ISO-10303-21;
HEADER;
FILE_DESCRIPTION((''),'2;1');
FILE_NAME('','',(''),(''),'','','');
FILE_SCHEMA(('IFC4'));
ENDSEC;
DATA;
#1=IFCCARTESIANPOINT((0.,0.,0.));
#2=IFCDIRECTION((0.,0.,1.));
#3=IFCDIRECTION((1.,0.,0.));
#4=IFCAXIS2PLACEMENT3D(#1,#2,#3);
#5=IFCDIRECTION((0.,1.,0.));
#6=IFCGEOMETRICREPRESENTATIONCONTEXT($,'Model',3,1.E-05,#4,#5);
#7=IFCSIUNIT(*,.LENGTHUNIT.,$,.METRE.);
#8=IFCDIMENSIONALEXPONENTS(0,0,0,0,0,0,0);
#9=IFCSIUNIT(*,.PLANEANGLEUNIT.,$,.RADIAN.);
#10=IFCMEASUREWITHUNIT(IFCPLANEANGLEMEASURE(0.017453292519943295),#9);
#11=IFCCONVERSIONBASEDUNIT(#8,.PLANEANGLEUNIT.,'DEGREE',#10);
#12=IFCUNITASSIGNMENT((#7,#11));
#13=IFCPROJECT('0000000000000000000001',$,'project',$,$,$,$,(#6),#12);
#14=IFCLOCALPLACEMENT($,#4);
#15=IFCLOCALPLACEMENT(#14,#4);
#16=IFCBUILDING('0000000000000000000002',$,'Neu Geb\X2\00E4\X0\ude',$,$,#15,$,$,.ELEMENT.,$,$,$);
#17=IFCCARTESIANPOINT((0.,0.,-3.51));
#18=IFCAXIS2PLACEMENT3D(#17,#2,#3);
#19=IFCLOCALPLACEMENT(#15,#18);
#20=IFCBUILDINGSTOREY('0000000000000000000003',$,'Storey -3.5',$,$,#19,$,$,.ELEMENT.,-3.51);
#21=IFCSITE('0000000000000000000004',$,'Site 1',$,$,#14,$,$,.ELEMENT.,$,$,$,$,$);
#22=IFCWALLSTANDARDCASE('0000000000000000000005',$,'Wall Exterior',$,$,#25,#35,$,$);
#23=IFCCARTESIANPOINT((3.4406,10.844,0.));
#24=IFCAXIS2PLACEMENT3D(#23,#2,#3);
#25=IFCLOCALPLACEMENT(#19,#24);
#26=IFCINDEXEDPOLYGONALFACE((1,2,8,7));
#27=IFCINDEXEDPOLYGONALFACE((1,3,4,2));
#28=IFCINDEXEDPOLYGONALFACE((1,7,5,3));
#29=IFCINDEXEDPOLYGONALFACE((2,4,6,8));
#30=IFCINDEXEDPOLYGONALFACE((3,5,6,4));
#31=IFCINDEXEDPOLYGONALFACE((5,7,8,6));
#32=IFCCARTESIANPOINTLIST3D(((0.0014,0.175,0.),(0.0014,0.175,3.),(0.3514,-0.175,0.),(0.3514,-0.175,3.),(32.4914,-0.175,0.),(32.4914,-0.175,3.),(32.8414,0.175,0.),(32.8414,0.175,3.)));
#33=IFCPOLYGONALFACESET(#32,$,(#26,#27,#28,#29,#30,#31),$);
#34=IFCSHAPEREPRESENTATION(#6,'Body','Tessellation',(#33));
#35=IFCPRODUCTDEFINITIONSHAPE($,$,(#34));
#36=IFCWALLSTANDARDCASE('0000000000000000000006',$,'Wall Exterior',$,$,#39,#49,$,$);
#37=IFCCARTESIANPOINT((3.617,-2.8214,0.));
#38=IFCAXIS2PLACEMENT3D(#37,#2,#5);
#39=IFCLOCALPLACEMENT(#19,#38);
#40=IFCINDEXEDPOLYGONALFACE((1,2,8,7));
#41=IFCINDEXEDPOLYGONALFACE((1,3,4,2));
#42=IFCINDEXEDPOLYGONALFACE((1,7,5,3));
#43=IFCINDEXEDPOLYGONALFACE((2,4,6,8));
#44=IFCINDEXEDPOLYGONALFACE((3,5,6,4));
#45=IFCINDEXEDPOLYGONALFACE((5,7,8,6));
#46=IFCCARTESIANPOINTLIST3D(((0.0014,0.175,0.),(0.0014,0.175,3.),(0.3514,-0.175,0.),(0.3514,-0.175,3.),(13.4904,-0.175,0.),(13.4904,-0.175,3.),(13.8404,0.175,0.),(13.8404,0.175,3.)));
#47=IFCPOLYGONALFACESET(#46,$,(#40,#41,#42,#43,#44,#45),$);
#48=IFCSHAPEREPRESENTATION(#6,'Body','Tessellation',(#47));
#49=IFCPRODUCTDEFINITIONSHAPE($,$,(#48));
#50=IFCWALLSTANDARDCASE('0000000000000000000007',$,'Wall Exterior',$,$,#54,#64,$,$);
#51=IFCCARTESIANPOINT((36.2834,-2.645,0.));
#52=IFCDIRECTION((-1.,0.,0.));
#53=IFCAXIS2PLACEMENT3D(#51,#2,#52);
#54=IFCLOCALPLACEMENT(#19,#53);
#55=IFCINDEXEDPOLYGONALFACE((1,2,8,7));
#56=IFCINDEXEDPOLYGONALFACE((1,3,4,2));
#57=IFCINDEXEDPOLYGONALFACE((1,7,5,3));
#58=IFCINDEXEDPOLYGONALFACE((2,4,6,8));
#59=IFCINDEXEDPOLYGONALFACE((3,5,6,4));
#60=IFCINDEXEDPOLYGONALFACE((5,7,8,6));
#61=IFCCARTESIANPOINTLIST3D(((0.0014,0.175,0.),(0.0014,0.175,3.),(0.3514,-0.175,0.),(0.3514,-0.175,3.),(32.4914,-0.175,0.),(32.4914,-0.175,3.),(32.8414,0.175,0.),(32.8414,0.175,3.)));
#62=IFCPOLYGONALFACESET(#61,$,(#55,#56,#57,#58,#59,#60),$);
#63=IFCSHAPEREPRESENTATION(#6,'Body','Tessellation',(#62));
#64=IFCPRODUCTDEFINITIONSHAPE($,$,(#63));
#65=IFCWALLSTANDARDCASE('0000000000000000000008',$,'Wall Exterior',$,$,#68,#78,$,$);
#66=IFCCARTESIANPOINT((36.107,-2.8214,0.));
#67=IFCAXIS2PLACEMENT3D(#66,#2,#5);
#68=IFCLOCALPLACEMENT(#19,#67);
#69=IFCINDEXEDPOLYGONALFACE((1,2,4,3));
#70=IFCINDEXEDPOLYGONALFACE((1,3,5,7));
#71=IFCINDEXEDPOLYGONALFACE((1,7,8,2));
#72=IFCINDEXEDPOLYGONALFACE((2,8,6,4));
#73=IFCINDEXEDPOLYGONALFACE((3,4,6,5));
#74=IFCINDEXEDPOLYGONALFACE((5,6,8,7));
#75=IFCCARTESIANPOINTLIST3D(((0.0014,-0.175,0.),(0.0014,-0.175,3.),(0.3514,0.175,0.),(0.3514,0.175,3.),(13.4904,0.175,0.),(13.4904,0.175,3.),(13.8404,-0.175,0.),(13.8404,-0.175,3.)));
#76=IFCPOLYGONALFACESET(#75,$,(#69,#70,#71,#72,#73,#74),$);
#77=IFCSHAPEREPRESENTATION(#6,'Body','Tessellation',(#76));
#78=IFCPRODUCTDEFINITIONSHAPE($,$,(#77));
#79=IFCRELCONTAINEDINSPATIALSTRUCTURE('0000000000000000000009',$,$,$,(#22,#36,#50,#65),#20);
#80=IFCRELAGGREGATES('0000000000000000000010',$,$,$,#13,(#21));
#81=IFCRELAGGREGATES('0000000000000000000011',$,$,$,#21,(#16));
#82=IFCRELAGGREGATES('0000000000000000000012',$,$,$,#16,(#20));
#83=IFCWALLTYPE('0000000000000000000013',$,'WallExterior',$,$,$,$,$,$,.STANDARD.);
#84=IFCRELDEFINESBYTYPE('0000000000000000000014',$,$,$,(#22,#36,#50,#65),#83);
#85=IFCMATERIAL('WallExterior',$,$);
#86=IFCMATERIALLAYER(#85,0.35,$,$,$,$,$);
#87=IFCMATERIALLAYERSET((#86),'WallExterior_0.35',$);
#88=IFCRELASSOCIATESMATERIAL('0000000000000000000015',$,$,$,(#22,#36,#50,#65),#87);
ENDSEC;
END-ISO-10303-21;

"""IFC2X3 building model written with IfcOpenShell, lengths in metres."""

from ifc_helpers import new_model, entity, si_unit, converted_unit, direction, frame, origin_with_axes, place, context, project, spatial, polyline, outline, extrude, material, layer, layer_set, layer_usage, type_object, element, save


model = new_model("IFC2X3")

# Units and contexts
model_context = context("Model", 3, precision=1e-05, world=origin_with_axes(), true_north=direction((0.0, 1.0, 0.0)))
ifc_project = project(units=[si_unit("LENGTHUNIT", "METRE"), converted_unit("PLANEANGLEUNIT", "DEGREE", entity("IfcPlaneAngleMeasure", 0.017453292519943295), si_unit("PLANEANGLEUNIT", "RADIAN"), dimensions=[0, 0, 0, 0, 0, 0, 0])], contexts=[model_context])

# Site, building, storey
site_placement = place(None, origin_with_axes())
site = spatial("IfcSite", under=ifc_project, at=site_placement, Name="Site 1", CompositionType="ELEMENT")
building_placement = place(site_placement, origin_with_axes())
building = spatial("IfcBuilding", under=site, at=building_placement, Name="Neu Gebäude", CompositionType="ELEMENT")
storey_placement = place(building_placement, frame((0.0, 0.0, -3.51), z_axis=(0.0, 0.0, 1.0), x_axis=(1.0, 0.0, 0.0)))
storey = spatial("IfcBuildingStorey", under=building, at=storey_placement, Name="Storey -3.5", CompositionType="ELEMENT", Elevation=-3.51)

# Walls
ifc_material_1 = material(Name="WallExterior")
ifc_layer_1 = layer(ifc_material_1, 0.35)
ifc_layer_set_1 = layer_set([ifc_layer_1], Name="WallExterior_0.35")
ifc_layer_usage_1 = layer_usage(ifc_layer_set_1, "AXIS2", "POSITIVE", -0.175)
wall_type_1 = type_object("IfcWallType", Name="WallExterior", PredefinedType="STANDARD")
wall_1_placement = place(storey_placement, frame((3.4406, 10.844, 0.0), z_axis=(0.0, 0.0, 1.0), x_axis=(1.0, 0.0, 0.0)))
element("IfcWallStandardCase", 1, at=wall_1_placement, inside=storey, type_object=wall_type_1, material=ifc_layer_usage_1, Name="Wall Exterior", context=model_context, shape_type="SweptSolid", body=[
    extrude(outline(polyline([(32.8414, 0.175), (0.0014, 0.175), (0.3514, -0.175), (32.4914, -0.175), (32.8414, 0.175)])), origin_with_axes(), (0.0, 0.0, 1.0), 3.0),
])
wall_2_placement = place(storey_placement, frame((3.617, -2.8214, 0.0), z_axis=(0.0, 0.0, 1.0), x_axis=(0.0, 1.0, 0.0)))
element("IfcWallStandardCase", 2, at=wall_2_placement, inside=storey, type_object=wall_type_1, material=ifc_layer_usage_1, Name="Wall Exterior", context=model_context, shape_type="SweptSolid", body=[
    extrude(outline(polyline([(0.3514, -0.175), (13.4904, -0.175), (13.8404, 0.175), (0.0014, 0.175), (0.3514, -0.175)])), origin_with_axes(), (0.0, 0.0, 1.0), 3.0),
])
wall_3_placement = place(storey_placement, frame((36.2834, -2.645, 0.0), z_axis=(0.0, 0.0, 1.0), x_axis=(-1.0, 0.0, 0.0)))
element("IfcWallStandardCase", 3, at=wall_3_placement, inside=storey, type_object=wall_type_1, material=ifc_layer_usage_1, Name="Wall Exterior", context=model_context, shape_type="SweptSolid", body=[
    extrude(outline(polyline([(0.3514, -0.175), (32.4914, -0.175), (32.8414, 0.175), (0.0014, 0.175), (0.3514, -0.175)])), origin_with_axes(), (0.0, 0.0, 1.0), 3.0),
])
wall_4_placement = place(storey_placement, frame((36.107, -2.8214, 0.0), z_axis=(0.0, 0.0, 1.0), x_axis=(0.0, 1.0, 0.0)))
element("IfcWallStandardCase", 4, at=wall_4_placement, inside=storey, type_object=wall_type_1, material=ifc_layer_usage_1, Name="Wall Exterior", context=model_context, shape_type="SweptSolid", body=[
    extrude(outline(polyline([(13.8404, -0.175), (13.4904, 0.175), (0.3514, 0.175), (0.0014, -0.175), (13.8404, -0.175)])), origin_with_axes(), (0.0, 0.0, 1.0), 3.0),
])

save(model, "model.ifc")
